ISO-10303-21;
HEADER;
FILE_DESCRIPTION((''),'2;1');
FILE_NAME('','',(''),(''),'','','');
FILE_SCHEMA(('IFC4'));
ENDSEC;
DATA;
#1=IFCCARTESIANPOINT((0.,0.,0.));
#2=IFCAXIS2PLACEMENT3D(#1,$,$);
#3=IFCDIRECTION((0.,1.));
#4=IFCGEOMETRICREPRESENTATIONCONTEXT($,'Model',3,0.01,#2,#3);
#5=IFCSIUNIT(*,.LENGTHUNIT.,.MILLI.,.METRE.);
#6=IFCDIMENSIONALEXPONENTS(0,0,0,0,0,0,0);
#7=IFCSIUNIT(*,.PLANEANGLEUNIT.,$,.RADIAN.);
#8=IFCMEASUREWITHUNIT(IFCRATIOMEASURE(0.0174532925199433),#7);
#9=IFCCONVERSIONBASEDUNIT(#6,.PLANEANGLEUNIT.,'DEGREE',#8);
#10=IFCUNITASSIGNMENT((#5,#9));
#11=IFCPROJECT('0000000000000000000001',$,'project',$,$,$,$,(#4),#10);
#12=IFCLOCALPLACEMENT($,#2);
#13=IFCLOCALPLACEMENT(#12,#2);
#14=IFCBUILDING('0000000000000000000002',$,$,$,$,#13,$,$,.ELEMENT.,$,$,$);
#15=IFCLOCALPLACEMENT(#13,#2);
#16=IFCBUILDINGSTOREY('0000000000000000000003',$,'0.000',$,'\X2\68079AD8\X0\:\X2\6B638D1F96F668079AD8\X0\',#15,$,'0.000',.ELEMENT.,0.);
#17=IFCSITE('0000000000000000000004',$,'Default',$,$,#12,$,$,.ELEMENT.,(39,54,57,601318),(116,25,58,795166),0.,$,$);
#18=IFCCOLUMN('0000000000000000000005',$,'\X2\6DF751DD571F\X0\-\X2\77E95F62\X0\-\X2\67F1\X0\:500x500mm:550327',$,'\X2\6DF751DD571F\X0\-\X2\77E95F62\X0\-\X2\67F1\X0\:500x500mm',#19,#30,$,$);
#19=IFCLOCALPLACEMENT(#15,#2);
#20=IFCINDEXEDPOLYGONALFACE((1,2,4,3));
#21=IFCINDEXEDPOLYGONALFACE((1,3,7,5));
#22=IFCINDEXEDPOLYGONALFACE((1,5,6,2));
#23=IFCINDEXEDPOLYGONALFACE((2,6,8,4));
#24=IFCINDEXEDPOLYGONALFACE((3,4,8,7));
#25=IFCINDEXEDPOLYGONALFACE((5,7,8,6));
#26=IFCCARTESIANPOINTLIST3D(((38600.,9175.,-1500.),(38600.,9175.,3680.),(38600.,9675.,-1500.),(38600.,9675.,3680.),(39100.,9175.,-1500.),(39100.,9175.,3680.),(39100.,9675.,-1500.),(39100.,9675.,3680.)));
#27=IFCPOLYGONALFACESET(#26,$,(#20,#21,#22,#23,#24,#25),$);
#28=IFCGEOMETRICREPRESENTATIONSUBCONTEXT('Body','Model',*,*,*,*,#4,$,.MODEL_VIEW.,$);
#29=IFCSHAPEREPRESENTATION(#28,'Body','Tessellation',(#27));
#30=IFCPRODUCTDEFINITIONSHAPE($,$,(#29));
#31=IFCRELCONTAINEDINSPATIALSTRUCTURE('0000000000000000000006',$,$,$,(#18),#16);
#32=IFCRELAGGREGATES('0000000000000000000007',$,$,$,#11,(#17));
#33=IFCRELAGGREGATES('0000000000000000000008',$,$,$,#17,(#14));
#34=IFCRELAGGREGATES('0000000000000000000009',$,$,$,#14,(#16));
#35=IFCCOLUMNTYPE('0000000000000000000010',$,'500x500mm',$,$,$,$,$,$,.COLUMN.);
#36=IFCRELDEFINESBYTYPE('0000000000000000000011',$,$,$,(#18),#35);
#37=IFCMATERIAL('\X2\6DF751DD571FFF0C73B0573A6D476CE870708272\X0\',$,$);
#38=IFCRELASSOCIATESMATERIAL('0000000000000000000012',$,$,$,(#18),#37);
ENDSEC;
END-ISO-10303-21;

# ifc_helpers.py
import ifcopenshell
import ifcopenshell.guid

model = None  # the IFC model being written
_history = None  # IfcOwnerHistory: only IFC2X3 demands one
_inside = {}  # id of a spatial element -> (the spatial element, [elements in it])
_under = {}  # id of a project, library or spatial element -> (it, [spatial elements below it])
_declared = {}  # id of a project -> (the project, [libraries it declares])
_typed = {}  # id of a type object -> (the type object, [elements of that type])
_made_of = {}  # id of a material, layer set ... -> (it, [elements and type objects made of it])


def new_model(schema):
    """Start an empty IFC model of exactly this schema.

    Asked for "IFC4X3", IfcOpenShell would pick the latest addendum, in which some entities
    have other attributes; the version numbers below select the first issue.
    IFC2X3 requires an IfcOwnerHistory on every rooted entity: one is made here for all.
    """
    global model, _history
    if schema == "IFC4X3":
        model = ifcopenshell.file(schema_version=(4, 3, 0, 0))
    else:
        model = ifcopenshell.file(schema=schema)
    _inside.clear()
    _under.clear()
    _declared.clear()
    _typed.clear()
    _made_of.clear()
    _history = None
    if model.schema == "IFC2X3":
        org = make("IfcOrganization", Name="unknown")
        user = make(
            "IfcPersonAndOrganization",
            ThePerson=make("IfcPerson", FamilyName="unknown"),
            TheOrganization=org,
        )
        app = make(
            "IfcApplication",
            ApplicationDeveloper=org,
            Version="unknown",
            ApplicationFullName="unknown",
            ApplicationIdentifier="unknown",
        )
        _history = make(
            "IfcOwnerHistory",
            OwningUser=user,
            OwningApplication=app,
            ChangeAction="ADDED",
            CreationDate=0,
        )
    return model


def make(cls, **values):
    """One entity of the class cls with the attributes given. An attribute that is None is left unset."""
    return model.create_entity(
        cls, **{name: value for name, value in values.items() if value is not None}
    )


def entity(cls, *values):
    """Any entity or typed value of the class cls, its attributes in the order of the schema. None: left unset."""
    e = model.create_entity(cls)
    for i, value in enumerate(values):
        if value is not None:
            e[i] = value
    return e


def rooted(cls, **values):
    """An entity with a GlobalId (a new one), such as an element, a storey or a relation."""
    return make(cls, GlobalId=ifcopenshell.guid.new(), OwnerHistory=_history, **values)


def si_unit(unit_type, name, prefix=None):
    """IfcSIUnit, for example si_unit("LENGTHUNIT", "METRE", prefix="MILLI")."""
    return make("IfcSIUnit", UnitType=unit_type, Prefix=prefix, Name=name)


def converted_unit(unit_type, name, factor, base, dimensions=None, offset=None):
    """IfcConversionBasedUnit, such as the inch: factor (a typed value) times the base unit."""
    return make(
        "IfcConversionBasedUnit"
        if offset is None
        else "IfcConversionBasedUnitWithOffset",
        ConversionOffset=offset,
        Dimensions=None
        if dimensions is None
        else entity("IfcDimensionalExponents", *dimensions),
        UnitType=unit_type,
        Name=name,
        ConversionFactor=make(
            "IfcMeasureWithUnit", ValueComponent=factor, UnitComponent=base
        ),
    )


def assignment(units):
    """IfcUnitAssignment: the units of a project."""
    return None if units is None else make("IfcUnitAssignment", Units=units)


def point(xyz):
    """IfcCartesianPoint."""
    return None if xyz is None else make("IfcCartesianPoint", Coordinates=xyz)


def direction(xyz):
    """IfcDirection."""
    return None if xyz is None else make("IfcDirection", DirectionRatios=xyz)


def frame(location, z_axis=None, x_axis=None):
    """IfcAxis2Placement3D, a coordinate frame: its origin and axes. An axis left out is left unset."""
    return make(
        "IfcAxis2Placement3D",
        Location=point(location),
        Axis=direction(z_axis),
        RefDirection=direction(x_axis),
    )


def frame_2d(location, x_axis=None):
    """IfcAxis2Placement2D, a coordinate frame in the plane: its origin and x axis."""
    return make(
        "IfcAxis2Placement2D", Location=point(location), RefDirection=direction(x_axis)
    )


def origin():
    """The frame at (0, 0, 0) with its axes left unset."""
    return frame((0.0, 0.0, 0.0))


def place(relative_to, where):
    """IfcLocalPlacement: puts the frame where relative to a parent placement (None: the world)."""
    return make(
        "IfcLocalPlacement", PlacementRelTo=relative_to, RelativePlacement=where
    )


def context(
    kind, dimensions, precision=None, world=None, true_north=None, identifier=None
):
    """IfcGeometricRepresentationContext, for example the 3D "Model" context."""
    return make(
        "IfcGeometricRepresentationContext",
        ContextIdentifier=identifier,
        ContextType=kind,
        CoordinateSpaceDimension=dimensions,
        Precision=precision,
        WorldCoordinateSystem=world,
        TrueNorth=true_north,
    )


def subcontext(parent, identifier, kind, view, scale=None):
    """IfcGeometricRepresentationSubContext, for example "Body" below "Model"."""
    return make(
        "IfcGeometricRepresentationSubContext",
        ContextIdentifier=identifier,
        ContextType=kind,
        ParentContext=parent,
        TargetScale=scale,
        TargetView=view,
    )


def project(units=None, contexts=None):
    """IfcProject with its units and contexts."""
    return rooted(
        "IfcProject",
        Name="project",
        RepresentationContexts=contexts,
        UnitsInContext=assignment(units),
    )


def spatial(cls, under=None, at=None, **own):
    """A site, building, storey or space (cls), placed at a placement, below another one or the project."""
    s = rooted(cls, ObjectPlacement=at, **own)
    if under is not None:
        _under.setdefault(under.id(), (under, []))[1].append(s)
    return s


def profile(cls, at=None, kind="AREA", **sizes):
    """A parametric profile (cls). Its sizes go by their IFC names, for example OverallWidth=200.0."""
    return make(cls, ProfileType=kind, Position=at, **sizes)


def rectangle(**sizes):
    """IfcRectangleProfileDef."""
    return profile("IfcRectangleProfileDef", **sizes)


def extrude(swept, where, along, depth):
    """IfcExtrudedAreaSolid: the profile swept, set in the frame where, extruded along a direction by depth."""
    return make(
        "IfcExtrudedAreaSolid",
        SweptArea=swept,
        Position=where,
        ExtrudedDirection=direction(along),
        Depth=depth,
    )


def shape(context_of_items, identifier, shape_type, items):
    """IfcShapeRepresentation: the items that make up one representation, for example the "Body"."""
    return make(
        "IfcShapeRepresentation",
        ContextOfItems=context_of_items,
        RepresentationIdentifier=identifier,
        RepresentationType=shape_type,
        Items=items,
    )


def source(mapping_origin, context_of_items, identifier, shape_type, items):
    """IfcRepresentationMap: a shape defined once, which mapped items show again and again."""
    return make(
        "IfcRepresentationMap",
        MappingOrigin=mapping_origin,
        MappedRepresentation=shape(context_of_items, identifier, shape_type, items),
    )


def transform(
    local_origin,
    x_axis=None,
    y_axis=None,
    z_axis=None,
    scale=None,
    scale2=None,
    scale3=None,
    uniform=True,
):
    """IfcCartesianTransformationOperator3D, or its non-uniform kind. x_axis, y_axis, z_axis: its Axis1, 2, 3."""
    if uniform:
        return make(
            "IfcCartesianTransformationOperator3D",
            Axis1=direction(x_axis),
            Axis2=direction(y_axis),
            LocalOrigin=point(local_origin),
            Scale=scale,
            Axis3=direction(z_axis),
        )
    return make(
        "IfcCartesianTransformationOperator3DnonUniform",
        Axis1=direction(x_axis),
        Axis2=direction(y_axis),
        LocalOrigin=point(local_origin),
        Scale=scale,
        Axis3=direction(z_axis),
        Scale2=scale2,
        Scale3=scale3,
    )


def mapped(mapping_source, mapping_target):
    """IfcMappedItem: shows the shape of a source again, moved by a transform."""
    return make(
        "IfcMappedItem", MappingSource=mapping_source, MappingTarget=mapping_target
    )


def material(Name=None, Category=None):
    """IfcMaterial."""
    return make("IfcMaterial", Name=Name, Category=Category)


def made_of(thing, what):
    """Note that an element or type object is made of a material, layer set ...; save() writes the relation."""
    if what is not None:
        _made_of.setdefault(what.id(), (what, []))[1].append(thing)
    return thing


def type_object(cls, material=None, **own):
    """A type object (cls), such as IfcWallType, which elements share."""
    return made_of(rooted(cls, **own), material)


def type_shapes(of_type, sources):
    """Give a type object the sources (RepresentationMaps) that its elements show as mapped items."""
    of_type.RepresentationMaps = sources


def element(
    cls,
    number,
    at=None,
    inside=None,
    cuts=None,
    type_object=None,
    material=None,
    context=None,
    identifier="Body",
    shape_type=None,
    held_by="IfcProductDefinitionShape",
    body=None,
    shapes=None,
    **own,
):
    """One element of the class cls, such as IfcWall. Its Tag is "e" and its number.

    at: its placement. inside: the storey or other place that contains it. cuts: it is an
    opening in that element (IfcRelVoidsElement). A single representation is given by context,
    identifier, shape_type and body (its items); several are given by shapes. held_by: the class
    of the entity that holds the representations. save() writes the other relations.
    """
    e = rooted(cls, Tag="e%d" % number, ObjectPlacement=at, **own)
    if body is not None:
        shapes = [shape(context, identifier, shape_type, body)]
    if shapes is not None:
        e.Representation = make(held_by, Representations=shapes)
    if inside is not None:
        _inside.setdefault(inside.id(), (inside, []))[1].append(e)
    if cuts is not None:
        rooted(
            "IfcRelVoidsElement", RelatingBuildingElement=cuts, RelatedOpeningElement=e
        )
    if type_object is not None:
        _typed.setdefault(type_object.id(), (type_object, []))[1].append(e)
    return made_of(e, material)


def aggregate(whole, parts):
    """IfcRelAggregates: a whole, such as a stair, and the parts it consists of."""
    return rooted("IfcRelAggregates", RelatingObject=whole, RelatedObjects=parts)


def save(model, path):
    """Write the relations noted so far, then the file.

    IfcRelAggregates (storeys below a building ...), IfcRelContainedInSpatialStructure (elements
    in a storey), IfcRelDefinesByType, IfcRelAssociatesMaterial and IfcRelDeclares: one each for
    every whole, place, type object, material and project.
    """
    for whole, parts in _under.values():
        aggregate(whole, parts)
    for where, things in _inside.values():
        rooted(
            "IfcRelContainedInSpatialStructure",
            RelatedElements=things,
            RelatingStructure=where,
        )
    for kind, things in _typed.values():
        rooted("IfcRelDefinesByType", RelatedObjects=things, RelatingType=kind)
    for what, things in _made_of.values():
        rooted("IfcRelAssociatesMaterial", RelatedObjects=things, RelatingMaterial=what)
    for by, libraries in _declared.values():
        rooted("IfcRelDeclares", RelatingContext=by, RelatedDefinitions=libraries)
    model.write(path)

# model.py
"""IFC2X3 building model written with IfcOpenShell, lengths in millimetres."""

from ifc_helpers import new_model, entity, si_unit, converted_unit, direction, frame, frame_2d, origin, place, context, subcontext, project, spatial, rectangle, extrude, source, transform, mapped, material, type_object, type_shapes, element, save


model = new_model("IFC2X3")

# Units and contexts
model_context = context("Model", 3, precision=0.01, world=origin(), true_north=direction((0.0, 1.0)))
body_context = subcontext(model_context, "Body", "Model", "MODEL_VIEW")
ifc_project = project(units=[si_unit("LENGTHUNIT", "METRE", prefix="MILLI"), converted_unit("PLANEANGLEUNIT", "DEGREE", entity("IfcRatioMeasure", 0.0174532925199433), si_unit("PLANEANGLEUNIT", "RADIAN"), dimensions=[0, 0, 0, 0, 0, 0, 0])], contexts=[model_context])

# Site, building, storey
site_placement = place(None, origin())
site = spatial("IfcSite", under=ifc_project, at=site_placement, Name="Default", CompositionType="ELEMENT", RefLatitude=(39, 54, 57, 601318), RefLongitude=(116, 25, 58, 795166), RefElevation=0.0)
building_placement = place(site_placement, origin())
building = spatial("IfcBuilding", under=site, at=building_placement, CompositionType="ELEMENT")
storey_placement = place(building_placement, origin())
storey = spatial("IfcBuildingStorey", under=building, at=storey_placement, Name="0.000", ObjectType="标高:正负零标高", LongName="0.000", CompositionType="ELEMENT", Elevation=0.0)

# Column
ifc_material = material(Name="混凝土，现场浇注灰色")
column_type_1 = type_object("IfcColumnType", Name="500x500mm", PredefinedType="COLUMN")
shared_shape_1 = source(origin(), body_context, "Body", "SweptSolid", [
    extrude(rectangle(XDim=500.0, YDim=500.0, at=frame_2d((0.0, 0.0), x_axis=(1.0, 0.0))), frame((38850.0, 9425.0, -1500.0), z_axis=(0.0, 0.0, 1.0), x_axis=(0.0, -1.0, 0.0)), (0.0, 0.0, 1.0), 5180.0),
])
type_shapes(column_type_1, [shared_shape_1])
column_1_placement = place(storey_placement, origin())
element("IfcColumn", 1, at=column_1_placement, inside=storey, type_object=column_type_1, material=ifc_material, Name="混凝土-矩形-柱:500x500mm:550327", ObjectType="混凝土-矩形-柱:500x500mm", context=body_context, shape_type="MappedRepresentation", body=[
    mapped(shared_shape_1, transform((0.0, 0.0, 0.0), scale=1.0)),
])

save(model, "model.ifc")
